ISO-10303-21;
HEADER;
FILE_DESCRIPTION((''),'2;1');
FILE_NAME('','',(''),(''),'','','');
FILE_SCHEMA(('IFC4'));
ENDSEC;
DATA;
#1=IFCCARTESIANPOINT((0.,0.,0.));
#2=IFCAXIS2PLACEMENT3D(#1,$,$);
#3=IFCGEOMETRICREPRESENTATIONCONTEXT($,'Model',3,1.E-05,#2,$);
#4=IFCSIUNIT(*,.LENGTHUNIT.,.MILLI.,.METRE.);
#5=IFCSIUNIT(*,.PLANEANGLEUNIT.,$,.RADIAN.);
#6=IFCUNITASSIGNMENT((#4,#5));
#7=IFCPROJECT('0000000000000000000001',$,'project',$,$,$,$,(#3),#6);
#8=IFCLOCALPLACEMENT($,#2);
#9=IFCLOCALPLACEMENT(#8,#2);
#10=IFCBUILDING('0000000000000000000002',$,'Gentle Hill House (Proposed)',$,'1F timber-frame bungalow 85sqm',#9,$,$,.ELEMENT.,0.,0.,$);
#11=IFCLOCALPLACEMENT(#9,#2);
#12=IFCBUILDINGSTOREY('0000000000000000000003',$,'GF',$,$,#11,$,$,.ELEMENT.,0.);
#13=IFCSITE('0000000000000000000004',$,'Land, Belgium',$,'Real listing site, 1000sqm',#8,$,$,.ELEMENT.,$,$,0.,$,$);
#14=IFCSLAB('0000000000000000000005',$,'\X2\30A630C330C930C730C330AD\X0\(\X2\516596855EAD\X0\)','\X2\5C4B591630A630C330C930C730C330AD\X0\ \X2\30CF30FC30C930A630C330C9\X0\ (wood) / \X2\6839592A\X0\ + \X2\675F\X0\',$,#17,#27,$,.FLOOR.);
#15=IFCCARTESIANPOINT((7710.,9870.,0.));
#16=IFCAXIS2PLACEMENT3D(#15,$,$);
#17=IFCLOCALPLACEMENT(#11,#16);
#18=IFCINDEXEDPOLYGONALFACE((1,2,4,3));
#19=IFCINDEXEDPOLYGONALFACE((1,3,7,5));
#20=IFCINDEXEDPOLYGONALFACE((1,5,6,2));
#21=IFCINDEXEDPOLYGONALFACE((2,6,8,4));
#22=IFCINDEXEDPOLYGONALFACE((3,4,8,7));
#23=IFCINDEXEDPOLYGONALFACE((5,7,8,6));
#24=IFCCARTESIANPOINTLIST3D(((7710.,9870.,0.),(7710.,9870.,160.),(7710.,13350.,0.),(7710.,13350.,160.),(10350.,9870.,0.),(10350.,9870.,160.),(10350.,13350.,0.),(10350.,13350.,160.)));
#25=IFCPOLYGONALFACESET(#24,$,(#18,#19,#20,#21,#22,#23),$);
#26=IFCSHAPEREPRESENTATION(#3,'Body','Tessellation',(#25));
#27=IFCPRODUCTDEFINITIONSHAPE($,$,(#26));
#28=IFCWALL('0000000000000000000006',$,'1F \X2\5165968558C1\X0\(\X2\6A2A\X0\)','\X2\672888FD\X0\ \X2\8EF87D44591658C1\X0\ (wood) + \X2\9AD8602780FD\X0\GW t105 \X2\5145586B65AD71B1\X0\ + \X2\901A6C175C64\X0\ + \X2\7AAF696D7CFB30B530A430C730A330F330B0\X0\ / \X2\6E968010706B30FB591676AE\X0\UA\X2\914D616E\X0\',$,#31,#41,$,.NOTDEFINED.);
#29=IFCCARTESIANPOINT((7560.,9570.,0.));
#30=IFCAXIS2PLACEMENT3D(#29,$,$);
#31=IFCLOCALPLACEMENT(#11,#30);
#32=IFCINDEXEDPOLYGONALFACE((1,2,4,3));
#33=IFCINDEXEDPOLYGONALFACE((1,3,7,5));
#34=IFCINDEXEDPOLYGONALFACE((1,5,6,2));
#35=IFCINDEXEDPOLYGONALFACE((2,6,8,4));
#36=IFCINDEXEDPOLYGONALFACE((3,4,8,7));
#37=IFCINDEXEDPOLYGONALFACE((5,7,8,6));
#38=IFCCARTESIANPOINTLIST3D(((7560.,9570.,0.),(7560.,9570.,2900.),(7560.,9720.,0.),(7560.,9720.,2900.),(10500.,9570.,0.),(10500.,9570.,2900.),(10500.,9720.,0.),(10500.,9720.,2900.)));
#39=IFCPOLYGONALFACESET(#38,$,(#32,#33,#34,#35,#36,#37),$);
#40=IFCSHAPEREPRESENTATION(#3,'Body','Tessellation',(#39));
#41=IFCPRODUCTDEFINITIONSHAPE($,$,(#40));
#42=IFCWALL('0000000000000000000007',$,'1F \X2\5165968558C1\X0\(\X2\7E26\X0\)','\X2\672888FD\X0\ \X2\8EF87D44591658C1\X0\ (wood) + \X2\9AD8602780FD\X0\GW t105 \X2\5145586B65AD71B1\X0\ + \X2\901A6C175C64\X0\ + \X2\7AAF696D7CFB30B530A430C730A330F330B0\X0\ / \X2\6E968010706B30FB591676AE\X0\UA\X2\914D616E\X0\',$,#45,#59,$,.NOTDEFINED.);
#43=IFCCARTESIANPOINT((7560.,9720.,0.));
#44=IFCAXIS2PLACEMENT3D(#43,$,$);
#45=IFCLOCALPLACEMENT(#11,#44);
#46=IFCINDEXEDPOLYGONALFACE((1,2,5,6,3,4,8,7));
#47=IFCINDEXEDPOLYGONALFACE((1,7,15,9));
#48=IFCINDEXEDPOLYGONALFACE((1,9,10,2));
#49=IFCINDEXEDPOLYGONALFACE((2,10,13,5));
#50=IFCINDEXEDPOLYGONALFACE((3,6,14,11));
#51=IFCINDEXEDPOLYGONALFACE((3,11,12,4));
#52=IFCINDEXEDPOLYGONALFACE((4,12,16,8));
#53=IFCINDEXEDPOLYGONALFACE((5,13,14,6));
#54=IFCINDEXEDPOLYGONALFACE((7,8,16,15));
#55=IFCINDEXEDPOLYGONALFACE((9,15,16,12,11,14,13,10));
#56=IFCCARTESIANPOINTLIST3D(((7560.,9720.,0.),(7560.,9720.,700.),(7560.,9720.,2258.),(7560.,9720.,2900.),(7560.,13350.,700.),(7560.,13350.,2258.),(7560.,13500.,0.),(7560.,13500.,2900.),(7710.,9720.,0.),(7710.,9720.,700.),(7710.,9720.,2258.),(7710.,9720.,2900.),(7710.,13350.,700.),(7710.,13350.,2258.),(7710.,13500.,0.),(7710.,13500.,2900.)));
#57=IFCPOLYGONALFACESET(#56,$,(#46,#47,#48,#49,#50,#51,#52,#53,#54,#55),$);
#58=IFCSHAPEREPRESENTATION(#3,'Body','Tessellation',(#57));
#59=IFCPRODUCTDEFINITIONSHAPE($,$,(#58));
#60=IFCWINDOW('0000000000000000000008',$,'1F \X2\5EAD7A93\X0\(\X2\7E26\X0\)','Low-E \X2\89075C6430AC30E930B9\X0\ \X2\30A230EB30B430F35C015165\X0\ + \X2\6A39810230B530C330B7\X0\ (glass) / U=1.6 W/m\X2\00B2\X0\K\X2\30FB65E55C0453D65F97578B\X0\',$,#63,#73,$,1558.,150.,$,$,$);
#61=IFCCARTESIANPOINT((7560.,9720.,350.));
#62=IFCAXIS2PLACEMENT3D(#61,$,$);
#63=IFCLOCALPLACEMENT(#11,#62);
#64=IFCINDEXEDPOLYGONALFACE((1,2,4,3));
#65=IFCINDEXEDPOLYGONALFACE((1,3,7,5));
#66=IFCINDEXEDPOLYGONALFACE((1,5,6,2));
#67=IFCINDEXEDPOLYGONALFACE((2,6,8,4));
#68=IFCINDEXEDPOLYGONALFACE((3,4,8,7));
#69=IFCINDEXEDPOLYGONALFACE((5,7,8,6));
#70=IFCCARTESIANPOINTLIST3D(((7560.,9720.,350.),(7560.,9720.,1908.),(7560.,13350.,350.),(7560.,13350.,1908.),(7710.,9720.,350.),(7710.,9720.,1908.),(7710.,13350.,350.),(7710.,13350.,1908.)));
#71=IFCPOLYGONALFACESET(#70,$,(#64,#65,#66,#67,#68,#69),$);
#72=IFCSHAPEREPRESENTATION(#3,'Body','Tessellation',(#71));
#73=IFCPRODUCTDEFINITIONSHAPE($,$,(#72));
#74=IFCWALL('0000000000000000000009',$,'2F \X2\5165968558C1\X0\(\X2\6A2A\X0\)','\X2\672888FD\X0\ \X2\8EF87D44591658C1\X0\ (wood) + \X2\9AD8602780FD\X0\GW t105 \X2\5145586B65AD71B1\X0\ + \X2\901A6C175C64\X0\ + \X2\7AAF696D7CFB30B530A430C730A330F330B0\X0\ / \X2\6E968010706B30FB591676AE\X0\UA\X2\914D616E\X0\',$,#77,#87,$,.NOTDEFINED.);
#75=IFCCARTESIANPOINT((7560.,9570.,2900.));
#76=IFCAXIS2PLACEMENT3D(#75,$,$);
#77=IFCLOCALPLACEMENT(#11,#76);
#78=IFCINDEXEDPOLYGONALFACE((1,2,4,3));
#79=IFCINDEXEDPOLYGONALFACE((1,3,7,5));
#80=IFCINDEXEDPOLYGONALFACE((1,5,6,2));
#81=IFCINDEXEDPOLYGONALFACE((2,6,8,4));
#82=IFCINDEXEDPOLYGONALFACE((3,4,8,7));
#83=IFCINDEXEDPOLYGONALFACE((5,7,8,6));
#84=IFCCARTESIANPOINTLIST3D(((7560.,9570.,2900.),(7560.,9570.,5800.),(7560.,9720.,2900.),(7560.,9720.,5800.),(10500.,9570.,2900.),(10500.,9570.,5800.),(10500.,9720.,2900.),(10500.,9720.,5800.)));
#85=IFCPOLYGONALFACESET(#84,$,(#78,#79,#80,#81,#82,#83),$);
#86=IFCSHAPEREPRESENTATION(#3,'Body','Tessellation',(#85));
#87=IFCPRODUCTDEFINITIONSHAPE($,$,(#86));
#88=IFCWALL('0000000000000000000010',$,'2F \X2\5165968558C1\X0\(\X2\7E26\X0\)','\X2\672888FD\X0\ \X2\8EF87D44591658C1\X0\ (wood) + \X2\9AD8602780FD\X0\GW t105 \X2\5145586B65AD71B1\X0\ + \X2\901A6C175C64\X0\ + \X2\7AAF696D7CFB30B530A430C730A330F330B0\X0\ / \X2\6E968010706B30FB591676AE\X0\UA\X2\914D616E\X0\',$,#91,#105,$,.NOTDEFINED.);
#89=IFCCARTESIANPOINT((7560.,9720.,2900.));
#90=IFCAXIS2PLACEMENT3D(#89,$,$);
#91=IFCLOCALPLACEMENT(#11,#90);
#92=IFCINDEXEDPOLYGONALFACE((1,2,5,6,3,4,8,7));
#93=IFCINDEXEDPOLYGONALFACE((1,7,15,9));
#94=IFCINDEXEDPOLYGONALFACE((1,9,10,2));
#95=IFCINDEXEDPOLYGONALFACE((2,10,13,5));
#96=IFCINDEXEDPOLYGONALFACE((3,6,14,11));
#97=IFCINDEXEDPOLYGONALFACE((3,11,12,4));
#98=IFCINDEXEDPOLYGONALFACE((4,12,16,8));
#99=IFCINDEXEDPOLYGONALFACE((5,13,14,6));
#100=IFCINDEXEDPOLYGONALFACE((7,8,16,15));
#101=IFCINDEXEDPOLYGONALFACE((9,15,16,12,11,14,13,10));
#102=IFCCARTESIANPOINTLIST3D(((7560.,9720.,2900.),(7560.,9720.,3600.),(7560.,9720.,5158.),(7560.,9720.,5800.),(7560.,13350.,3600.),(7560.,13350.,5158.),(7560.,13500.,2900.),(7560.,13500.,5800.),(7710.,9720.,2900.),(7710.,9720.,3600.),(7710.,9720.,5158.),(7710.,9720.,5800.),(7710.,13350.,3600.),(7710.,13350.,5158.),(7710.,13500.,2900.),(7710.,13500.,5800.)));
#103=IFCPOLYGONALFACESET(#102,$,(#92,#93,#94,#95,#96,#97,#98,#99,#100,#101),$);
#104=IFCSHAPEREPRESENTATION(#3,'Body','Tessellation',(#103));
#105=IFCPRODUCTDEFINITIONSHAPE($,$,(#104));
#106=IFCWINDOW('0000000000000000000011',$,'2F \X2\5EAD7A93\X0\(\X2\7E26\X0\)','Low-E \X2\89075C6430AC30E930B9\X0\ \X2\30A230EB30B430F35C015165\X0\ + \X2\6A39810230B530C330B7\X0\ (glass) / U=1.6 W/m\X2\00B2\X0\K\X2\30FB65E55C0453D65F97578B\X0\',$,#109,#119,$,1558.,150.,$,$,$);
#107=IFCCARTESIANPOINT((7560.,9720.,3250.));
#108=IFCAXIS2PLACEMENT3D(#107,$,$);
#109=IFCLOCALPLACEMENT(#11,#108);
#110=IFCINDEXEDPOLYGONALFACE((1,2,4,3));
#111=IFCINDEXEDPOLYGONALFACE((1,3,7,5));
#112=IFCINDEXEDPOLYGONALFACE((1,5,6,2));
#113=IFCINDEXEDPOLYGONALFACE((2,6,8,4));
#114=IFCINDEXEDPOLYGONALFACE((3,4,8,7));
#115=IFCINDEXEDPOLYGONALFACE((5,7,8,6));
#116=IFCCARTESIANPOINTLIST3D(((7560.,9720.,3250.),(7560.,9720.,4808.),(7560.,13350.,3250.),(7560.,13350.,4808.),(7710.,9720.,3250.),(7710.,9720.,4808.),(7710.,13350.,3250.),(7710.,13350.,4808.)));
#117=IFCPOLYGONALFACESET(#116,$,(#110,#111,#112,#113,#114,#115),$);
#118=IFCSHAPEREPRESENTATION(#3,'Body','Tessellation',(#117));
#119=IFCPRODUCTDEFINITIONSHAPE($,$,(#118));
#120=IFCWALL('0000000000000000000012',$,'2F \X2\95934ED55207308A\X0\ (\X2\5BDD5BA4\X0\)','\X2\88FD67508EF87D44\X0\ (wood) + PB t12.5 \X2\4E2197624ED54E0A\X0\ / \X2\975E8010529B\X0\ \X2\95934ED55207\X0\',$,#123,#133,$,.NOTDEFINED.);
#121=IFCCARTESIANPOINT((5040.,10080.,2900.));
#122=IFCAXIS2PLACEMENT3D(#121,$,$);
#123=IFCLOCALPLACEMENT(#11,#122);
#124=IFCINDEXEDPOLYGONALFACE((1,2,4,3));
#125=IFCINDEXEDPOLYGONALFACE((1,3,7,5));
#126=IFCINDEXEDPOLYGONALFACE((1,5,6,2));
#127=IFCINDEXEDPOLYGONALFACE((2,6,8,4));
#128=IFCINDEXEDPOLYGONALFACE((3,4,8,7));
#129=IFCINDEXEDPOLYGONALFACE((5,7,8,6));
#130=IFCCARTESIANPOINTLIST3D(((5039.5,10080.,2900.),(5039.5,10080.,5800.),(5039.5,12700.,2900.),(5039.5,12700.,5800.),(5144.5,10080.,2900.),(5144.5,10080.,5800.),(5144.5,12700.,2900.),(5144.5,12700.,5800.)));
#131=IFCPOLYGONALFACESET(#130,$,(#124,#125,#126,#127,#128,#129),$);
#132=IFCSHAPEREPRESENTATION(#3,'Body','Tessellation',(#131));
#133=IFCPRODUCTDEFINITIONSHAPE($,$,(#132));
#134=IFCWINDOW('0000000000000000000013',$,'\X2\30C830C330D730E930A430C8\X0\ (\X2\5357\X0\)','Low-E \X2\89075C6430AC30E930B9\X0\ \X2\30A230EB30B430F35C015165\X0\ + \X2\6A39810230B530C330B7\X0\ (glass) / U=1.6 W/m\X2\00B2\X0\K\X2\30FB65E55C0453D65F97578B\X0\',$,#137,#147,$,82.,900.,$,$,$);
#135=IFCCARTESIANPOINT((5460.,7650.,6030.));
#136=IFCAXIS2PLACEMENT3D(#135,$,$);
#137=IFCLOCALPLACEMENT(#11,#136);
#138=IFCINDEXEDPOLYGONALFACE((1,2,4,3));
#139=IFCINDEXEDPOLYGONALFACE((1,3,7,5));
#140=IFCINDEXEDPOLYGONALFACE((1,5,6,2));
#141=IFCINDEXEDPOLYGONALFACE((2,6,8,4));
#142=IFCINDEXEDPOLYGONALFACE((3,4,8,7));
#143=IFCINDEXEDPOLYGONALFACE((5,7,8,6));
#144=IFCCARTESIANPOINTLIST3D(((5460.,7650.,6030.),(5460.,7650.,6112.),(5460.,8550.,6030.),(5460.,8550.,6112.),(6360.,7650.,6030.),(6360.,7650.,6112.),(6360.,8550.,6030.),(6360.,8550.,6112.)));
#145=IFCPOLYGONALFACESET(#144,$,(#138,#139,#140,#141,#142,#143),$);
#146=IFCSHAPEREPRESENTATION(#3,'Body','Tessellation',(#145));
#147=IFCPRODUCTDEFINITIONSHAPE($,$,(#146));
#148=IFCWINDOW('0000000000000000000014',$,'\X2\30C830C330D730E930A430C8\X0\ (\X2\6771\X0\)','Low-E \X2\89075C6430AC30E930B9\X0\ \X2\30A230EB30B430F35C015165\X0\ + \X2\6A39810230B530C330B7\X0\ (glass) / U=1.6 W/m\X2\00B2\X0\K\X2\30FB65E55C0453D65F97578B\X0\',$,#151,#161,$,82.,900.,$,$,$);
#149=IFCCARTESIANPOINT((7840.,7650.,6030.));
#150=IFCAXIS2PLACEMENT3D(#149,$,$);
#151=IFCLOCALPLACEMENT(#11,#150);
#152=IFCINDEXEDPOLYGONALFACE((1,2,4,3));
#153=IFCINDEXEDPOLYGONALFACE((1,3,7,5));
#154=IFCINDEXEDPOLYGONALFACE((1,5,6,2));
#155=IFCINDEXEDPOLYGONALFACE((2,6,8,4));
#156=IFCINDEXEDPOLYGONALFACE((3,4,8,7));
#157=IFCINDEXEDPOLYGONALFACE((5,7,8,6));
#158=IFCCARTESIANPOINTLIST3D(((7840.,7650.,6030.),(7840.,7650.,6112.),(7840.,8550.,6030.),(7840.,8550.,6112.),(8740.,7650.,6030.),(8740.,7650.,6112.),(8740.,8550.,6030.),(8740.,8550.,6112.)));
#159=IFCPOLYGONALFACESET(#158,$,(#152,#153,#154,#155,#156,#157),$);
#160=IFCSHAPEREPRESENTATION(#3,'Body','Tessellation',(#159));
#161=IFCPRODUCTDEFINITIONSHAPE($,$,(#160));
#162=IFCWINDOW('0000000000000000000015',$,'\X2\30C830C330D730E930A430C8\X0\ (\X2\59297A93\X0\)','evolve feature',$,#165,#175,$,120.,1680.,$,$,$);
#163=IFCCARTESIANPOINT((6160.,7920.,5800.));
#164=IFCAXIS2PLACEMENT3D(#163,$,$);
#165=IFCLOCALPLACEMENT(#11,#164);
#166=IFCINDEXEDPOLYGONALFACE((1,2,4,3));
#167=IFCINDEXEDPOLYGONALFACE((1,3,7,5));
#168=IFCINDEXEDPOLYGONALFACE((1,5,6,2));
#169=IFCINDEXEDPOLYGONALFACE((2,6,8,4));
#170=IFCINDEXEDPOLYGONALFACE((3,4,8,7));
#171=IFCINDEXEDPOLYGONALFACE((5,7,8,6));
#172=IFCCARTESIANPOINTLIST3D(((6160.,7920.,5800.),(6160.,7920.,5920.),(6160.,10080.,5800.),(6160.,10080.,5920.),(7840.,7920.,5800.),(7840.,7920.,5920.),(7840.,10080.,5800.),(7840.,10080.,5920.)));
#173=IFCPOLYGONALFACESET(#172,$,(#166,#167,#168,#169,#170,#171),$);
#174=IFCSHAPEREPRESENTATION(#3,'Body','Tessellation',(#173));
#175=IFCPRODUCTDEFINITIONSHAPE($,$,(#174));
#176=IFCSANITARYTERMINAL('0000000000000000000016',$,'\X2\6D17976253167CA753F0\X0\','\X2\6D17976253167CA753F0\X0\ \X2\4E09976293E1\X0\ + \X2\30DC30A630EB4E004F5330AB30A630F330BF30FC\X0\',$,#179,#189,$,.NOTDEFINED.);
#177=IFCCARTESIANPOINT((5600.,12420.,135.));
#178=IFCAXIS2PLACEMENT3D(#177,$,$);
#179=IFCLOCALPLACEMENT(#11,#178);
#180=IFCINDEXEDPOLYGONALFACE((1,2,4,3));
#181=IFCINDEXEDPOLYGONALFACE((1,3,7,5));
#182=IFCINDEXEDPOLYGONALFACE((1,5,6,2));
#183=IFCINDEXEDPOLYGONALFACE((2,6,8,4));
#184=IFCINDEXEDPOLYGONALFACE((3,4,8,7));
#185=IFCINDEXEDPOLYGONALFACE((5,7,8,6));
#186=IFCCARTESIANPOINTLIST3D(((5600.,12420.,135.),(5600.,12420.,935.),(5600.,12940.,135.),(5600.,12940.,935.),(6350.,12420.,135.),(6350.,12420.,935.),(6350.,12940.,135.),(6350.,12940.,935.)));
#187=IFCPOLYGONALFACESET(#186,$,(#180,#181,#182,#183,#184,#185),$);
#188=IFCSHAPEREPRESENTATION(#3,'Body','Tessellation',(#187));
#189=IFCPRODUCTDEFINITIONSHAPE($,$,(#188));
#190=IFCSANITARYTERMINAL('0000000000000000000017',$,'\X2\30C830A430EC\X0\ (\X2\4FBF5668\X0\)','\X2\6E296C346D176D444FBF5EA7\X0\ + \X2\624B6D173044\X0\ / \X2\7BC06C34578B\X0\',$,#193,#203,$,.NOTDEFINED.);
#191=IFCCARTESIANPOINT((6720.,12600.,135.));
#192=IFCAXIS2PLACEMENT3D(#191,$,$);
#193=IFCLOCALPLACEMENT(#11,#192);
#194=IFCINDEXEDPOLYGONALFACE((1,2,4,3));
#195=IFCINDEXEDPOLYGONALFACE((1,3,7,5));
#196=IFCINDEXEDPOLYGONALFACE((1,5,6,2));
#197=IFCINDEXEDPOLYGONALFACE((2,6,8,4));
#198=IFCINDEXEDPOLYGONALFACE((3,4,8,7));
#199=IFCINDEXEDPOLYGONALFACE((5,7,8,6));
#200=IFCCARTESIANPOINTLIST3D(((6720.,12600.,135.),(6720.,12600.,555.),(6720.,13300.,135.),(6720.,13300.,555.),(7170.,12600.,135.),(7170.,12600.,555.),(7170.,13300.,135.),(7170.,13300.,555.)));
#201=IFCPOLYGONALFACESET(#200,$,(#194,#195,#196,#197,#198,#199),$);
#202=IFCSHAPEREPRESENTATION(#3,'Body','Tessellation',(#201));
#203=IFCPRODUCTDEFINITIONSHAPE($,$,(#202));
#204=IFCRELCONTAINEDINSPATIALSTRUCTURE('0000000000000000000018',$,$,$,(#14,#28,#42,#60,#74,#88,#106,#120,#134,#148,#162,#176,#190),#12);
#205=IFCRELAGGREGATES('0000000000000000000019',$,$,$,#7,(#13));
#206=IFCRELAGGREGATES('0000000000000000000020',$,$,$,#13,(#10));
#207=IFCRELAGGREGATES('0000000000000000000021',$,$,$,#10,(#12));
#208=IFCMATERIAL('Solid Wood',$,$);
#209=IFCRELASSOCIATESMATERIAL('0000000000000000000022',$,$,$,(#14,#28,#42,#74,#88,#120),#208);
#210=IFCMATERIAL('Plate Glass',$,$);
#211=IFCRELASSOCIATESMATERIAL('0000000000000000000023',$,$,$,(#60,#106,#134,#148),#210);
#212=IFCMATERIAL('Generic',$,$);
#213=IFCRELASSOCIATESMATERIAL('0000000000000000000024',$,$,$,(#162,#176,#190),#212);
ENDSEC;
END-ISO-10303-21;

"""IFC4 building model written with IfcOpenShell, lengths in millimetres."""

from ifc_helpers import new_model, si_unit, frame, frame_2d, origin, place, context, project, spatial, rectangle, extrude, material, element, fill, save


model = new_model("IFC4")

# Units and contexts
model_context = context("Model", 3, precision=1e-05, world=origin())
ifc_project = project(units=[si_unit("LENGTHUNIT", "METRE", prefix="MILLI"), si_unit("PLANEANGLEUNIT", "RADIAN")], contexts=[model_context])

# Site, building, storey
site_placement = place(None, origin())
site = spatial("IfcSite", under=ifc_project, at=site_placement, Name="Land, Belgium", ObjectType="Real listing site, 1000sqm", CompositionType="ELEMENT", RefElevation=0.0)
building_placement = place(site_placement, origin())
building = spatial("IfcBuilding", under=site, at=building_placement, Name="Gentle Hill House (Proposed)", ObjectType="1F timber-frame bungalow 85sqm", CompositionType="ELEMENT", ElevationOfRefHeight=0.0, ElevationOfTerrain=0.0)
storey_placement = place(building_placement, origin())
storey = spatial("IfcBuildingStorey", under=building, at=storey_placement, Name="GF", CompositionType="ELEMENT", Elevation=0.0)

# Slab
ifc_material_1 = material(Name="Solid Wood")
slab_placement = place(storey_placement, frame((7710.0, 9870.0, 0.0)))
element("IfcSlab", 1, at=slab_placement, inside=storey, material=ifc_material_1, Name="ウッドデッキ(入隅庭)", Description="屋外ウッドデッキ ハードウッド (wood) / 根太 + 束", PredefinedType="FLOOR", context=model_context, shape_type="SweptSolid", body=[
    extrude(rectangle(XDim=2640.0, YDim=3480.0, at=frame_2d((1320.0, 1740.0))), frame((7710.0, 9870.0, 0.0)), (0.0, 0.0, 1.0), 160.0),
])

# Wall
wall_1_placement = place(storey_placement, frame((7560.0, 9570.0, 0.0)))
element("IfcWall", 2, at=wall_1_placement, inside=storey, material=ifc_material_1, Name="1F 入隅壁(横)", Description="木製 軸組外壁 (wood) + 高性能GW t105 充填断熱 + 通気層 + 窯業系サイディング / 準耐火・外皮UA配慮", PredefinedType="NOTDEFINED", context=model_context, shape_type="SweptSolid", body=[
    extrude(rectangle(XDim=2940.0, YDim=150.0, at=frame_2d((1470.0, 75.0))), frame((7560.0, 9570.0, 0.0)), (0.0, 0.0, 1.0), 2900.0),
])

# Wall, opening, window
wall_2_placement = place(storey_placement, frame((7560.0, 9720.0, 0.0)))
wall_2 = element("IfcWall", 3, at=wall_2_placement, inside=storey, material=ifc_material_1, Name="1F 入隅壁(縦)", Description="木製 軸組外壁 (wood) + 高性能GW t105 充填断熱 + 通気層 + 窯業系サイディング / 準耐火・外皮UA配慮", PredefinedType="NOTDEFINED", context=model_context, shape_type="SweptSolid", body=[
    extrude(rectangle(XDim=150.0, YDim=3780.0, at=frame_2d((75.0, 1890.0))), frame((7560.0, 9720.0, 0.0)), (0.0, 0.0, 1.0), 2900.0),
])
opening_1_placement = place(storey_placement, frame((7560.0, 9720.0, 350.0)))
opening_1 = element("IfcOpeningElement", 4, at=opening_1_placement, cuts=wall_2, PredefinedType="NOTDEFINED", context=model_context, shape_type="SweptSolid", body=[
    extrude(rectangle(XDim=150.0, YDim=3630.0, at=frame_2d((75.0, 1815.0))), frame((7560.0, 9720.0, 350.0)), (0.0, 0.0, 1.0), 1558.0),
])
ifc_material_2 = material(Name="Plate Glass")
window_1_placement = place(storey_placement, frame((7560.0, 9720.0, 350.0)))
window_1 = element("IfcWindow", 5, at=window_1_placement, inside=storey, material=ifc_material_2, Name="1F 庭窓(縦)", Description="Low-E 複層ガラス アルゴン封入 + 樹脂サッシ (glass) / U=1.6 W/m²K・日射取得型", OverallHeight=1558.0, OverallWidth=150.0, context=model_context, shape_type="SweptSolid", body=[
    extrude(rectangle(XDim=150.0, YDim=3630.0, at=frame_2d((75.0, 1815.0))), frame((7560.0, 9720.0, 350.0)), (0.0, 0.0, 1.0), 1558.0),
])
fill(opening_1, window_1)

# Wall
wall_3_placement = place(storey_placement, frame((7560.0, 9570.0, 2900.0)))
element("IfcWall", 6, at=wall_3_placement, inside=storey, material=ifc_material_1, Name="2F 入隅壁(横)", Description="木製 軸組外壁 (wood) + 高性能GW t105 充填断熱 + 通気層 + 窯業系サイディング / 準耐火・外皮UA配慮", PredefinedType="NOTDEFINED", context=model_context, shape_type="SweptSolid", body=[
    extrude(rectangle(XDim=2940.0, YDim=150.0, at=frame_2d((1470.0, 75.0))), frame((7560.0, 9570.0, 2900.0)), (0.0, 0.0, 1.0), 2900.0),
])

# Wall, opening, window
wall_4_placement = place(storey_placement, frame((7560.0, 9720.0, 2900.0)))
wall_4 = element("IfcWall", 7, at=wall_4_placement, inside=storey, material=ifc_material_1, Name="2F 入隅壁(縦)", Description="木製 軸組外壁 (wood) + 高性能GW t105 充填断熱 + 通気層 + 窯業系サイディング / 準耐火・外皮UA配慮", PredefinedType="NOTDEFINED", context=model_context, shape_type="SweptSolid", body=[
    extrude(rectangle(XDim=150.0, YDim=3780.0, at=frame_2d((75.0, 1890.0))), frame((7560.0, 9720.0, 2900.0)), (0.0, 0.0, 1.0), 2900.0),
])
opening_2_placement = place(storey_placement, frame((7560.0, 9720.0, 3250.0)))
opening_2 = element("IfcOpeningElement", 8, at=opening_2_placement, cuts=wall_4, PredefinedType="NOTDEFINED", context=model_context, shape_type="SweptSolid", body=[
    extrude(rectangle(XDim=150.0, YDim=3630.0, at=frame_2d((75.0, 1815.0))), frame((7560.0, 9720.0, 3250.0)), (0.0, 0.0, 1.0), 1558.0),
])
window_2_placement = place(storey_placement, frame((7560.0, 9720.0, 3250.0)))
window_2 = element("IfcWindow", 9, at=window_2_placement, inside=storey, material=ifc_material_2, Name="2F 庭窓(縦)", Description="Low-E 複層ガラス アルゴン封入 + 樹脂サッシ (glass) / U=1.6 W/m²K・日射取得型", OverallHeight=1558.0, OverallWidth=150.0, context=model_context, shape_type="SweptSolid", body=[
    extrude(rectangle(XDim=150.0, YDim=3630.0, at=frame_2d((75.0, 1815.0))), frame((7560.0, 9720.0, 3250.0)), (0.0, 0.0, 1.0), 1558.0),
])
fill(opening_2, window_2)

# Wall
wall_5_placement = place(storey_placement, frame((5040.0, 10080.0, 2900.0)))
element("IfcWall", 10, at=wall_5_placement, inside=storey, material=ifc_material_1, Name="2F 間仕切り (寝室)", Description="製材軸組 (wood) + PB t12.5 両面仕上 / 非耐力 間仕切", PredefinedType="NOTDEFINED", context=model_context, shape_type="SweptSolid", body=[
    extrude(rectangle(XDim=105.0, YDim=2620.0, at=frame_2d((52.0, 1310.0))), frame((5040.0, 10080.0, 2900.0)), (0.0, 0.0, 1.0), 2900.0),
])

# Windows
window_3_placement = place(storey_placement, frame((5460.0, 7650.0, 6030.0)))
element("IfcWindow", 11, at=window_3_placement, inside=storey, material=ifc_material_2, Name="トップライト (南)", Description="Low-E 複層ガラス アルゴン封入 + 樹脂サッシ (glass) / U=1.6 W/m²K・日射取得型", OverallHeight=82.0, OverallWidth=900.0, context=model_context, shape_type="SweptSolid", body=[
    extrude(rectangle(XDim=900.0, YDim=900.0, at=frame_2d((450.0, 450.0))), frame((5460.0, 7650.0, 6030.0)), (0.0, 0.0, 1.0), 82.0),
])
window_4_placement = place(storey_placement, frame((7840.0, 7650.0, 6030.0)))
element("IfcWindow", 12, at=window_4_placement, inside=storey, material=ifc_material_2, Name="トップライト (東)", Description="Low-E 複層ガラス アルゴン封入 + 樹脂サッシ (glass) / U=1.6 W/m²K・日射取得型", OverallHeight=82.0, OverallWidth=900.0, context=model_context, shape_type="SweptSolid", body=[
    extrude(rectangle(XDim=900.0, YDim=900.0, at=frame_2d((450.0, 450.0))), frame((7840.0, 7650.0, 6030.0)), (0.0, 0.0, 1.0), 82.0),
])
ifc_material_3 = material(Name="Generic")
window_5_placement = place(storey_placement, frame((6160.0, 7920.0, 5800.0)))
element("IfcWindow", 13, at=window_5_placement, inside=storey, material=ifc_material_3, Name="トップライト (天窓)", Description="evolve feature", OverallHeight=120.0, OverallWidth=1680.0, context=model_context, shape_type="SweptSolid", body=[
    extrude(rectangle(XDim=1680.0, YDim=2160.0, at=frame_2d((840.0, 1080.0))), frame((6160.0, 7920.0, 5800.0)), (0.0, 0.0, 1.0), 120.0),
])

# Sanitary terminals
sanitary_terminal_1_placement = place(storey_placement, frame((5600.0, 12420.0, 135.0)))
element("IfcSanitaryTerminal", 14, at=sanitary_terminal_1_placement, inside=storey, material=ifc_material_3, Name="洗面化粧台", Description="洗面化粧台 三面鏡 + ボウル一体カウンター", PredefinedType="NOTDEFINED", context=model_context, shape_type="SweptSolid", body=[
    extrude(rectangle(XDim=750.0, YDim=520.0, at=frame_2d((375.0, 260.0))), frame((5600.0, 12420.0, 135.0)), (0.0, 0.0, 1.0), 800.0),
])
sanitary_terminal_2_placement = place(storey_placement, frame((6720.0, 12600.0, 135.0)))
element("IfcSanitaryTerminal", 15, at=sanitary_terminal_2_placement, inside=storey, material=ifc_material_3, Name="トイレ (便器)", Description="温水洗浄便座 + 手洗い / 節水型", PredefinedType="NOTDEFINED", context=model_context, shape_type="SweptSolid", body=[
    extrude(rectangle(XDim=450.0, YDim=700.0, at=frame_2d((225.0, 350.0))), frame((6720.0, 12600.0, 135.0)), (0.0, 0.0, 1.0), 420.0),
])

save(model, "model.ifc")
